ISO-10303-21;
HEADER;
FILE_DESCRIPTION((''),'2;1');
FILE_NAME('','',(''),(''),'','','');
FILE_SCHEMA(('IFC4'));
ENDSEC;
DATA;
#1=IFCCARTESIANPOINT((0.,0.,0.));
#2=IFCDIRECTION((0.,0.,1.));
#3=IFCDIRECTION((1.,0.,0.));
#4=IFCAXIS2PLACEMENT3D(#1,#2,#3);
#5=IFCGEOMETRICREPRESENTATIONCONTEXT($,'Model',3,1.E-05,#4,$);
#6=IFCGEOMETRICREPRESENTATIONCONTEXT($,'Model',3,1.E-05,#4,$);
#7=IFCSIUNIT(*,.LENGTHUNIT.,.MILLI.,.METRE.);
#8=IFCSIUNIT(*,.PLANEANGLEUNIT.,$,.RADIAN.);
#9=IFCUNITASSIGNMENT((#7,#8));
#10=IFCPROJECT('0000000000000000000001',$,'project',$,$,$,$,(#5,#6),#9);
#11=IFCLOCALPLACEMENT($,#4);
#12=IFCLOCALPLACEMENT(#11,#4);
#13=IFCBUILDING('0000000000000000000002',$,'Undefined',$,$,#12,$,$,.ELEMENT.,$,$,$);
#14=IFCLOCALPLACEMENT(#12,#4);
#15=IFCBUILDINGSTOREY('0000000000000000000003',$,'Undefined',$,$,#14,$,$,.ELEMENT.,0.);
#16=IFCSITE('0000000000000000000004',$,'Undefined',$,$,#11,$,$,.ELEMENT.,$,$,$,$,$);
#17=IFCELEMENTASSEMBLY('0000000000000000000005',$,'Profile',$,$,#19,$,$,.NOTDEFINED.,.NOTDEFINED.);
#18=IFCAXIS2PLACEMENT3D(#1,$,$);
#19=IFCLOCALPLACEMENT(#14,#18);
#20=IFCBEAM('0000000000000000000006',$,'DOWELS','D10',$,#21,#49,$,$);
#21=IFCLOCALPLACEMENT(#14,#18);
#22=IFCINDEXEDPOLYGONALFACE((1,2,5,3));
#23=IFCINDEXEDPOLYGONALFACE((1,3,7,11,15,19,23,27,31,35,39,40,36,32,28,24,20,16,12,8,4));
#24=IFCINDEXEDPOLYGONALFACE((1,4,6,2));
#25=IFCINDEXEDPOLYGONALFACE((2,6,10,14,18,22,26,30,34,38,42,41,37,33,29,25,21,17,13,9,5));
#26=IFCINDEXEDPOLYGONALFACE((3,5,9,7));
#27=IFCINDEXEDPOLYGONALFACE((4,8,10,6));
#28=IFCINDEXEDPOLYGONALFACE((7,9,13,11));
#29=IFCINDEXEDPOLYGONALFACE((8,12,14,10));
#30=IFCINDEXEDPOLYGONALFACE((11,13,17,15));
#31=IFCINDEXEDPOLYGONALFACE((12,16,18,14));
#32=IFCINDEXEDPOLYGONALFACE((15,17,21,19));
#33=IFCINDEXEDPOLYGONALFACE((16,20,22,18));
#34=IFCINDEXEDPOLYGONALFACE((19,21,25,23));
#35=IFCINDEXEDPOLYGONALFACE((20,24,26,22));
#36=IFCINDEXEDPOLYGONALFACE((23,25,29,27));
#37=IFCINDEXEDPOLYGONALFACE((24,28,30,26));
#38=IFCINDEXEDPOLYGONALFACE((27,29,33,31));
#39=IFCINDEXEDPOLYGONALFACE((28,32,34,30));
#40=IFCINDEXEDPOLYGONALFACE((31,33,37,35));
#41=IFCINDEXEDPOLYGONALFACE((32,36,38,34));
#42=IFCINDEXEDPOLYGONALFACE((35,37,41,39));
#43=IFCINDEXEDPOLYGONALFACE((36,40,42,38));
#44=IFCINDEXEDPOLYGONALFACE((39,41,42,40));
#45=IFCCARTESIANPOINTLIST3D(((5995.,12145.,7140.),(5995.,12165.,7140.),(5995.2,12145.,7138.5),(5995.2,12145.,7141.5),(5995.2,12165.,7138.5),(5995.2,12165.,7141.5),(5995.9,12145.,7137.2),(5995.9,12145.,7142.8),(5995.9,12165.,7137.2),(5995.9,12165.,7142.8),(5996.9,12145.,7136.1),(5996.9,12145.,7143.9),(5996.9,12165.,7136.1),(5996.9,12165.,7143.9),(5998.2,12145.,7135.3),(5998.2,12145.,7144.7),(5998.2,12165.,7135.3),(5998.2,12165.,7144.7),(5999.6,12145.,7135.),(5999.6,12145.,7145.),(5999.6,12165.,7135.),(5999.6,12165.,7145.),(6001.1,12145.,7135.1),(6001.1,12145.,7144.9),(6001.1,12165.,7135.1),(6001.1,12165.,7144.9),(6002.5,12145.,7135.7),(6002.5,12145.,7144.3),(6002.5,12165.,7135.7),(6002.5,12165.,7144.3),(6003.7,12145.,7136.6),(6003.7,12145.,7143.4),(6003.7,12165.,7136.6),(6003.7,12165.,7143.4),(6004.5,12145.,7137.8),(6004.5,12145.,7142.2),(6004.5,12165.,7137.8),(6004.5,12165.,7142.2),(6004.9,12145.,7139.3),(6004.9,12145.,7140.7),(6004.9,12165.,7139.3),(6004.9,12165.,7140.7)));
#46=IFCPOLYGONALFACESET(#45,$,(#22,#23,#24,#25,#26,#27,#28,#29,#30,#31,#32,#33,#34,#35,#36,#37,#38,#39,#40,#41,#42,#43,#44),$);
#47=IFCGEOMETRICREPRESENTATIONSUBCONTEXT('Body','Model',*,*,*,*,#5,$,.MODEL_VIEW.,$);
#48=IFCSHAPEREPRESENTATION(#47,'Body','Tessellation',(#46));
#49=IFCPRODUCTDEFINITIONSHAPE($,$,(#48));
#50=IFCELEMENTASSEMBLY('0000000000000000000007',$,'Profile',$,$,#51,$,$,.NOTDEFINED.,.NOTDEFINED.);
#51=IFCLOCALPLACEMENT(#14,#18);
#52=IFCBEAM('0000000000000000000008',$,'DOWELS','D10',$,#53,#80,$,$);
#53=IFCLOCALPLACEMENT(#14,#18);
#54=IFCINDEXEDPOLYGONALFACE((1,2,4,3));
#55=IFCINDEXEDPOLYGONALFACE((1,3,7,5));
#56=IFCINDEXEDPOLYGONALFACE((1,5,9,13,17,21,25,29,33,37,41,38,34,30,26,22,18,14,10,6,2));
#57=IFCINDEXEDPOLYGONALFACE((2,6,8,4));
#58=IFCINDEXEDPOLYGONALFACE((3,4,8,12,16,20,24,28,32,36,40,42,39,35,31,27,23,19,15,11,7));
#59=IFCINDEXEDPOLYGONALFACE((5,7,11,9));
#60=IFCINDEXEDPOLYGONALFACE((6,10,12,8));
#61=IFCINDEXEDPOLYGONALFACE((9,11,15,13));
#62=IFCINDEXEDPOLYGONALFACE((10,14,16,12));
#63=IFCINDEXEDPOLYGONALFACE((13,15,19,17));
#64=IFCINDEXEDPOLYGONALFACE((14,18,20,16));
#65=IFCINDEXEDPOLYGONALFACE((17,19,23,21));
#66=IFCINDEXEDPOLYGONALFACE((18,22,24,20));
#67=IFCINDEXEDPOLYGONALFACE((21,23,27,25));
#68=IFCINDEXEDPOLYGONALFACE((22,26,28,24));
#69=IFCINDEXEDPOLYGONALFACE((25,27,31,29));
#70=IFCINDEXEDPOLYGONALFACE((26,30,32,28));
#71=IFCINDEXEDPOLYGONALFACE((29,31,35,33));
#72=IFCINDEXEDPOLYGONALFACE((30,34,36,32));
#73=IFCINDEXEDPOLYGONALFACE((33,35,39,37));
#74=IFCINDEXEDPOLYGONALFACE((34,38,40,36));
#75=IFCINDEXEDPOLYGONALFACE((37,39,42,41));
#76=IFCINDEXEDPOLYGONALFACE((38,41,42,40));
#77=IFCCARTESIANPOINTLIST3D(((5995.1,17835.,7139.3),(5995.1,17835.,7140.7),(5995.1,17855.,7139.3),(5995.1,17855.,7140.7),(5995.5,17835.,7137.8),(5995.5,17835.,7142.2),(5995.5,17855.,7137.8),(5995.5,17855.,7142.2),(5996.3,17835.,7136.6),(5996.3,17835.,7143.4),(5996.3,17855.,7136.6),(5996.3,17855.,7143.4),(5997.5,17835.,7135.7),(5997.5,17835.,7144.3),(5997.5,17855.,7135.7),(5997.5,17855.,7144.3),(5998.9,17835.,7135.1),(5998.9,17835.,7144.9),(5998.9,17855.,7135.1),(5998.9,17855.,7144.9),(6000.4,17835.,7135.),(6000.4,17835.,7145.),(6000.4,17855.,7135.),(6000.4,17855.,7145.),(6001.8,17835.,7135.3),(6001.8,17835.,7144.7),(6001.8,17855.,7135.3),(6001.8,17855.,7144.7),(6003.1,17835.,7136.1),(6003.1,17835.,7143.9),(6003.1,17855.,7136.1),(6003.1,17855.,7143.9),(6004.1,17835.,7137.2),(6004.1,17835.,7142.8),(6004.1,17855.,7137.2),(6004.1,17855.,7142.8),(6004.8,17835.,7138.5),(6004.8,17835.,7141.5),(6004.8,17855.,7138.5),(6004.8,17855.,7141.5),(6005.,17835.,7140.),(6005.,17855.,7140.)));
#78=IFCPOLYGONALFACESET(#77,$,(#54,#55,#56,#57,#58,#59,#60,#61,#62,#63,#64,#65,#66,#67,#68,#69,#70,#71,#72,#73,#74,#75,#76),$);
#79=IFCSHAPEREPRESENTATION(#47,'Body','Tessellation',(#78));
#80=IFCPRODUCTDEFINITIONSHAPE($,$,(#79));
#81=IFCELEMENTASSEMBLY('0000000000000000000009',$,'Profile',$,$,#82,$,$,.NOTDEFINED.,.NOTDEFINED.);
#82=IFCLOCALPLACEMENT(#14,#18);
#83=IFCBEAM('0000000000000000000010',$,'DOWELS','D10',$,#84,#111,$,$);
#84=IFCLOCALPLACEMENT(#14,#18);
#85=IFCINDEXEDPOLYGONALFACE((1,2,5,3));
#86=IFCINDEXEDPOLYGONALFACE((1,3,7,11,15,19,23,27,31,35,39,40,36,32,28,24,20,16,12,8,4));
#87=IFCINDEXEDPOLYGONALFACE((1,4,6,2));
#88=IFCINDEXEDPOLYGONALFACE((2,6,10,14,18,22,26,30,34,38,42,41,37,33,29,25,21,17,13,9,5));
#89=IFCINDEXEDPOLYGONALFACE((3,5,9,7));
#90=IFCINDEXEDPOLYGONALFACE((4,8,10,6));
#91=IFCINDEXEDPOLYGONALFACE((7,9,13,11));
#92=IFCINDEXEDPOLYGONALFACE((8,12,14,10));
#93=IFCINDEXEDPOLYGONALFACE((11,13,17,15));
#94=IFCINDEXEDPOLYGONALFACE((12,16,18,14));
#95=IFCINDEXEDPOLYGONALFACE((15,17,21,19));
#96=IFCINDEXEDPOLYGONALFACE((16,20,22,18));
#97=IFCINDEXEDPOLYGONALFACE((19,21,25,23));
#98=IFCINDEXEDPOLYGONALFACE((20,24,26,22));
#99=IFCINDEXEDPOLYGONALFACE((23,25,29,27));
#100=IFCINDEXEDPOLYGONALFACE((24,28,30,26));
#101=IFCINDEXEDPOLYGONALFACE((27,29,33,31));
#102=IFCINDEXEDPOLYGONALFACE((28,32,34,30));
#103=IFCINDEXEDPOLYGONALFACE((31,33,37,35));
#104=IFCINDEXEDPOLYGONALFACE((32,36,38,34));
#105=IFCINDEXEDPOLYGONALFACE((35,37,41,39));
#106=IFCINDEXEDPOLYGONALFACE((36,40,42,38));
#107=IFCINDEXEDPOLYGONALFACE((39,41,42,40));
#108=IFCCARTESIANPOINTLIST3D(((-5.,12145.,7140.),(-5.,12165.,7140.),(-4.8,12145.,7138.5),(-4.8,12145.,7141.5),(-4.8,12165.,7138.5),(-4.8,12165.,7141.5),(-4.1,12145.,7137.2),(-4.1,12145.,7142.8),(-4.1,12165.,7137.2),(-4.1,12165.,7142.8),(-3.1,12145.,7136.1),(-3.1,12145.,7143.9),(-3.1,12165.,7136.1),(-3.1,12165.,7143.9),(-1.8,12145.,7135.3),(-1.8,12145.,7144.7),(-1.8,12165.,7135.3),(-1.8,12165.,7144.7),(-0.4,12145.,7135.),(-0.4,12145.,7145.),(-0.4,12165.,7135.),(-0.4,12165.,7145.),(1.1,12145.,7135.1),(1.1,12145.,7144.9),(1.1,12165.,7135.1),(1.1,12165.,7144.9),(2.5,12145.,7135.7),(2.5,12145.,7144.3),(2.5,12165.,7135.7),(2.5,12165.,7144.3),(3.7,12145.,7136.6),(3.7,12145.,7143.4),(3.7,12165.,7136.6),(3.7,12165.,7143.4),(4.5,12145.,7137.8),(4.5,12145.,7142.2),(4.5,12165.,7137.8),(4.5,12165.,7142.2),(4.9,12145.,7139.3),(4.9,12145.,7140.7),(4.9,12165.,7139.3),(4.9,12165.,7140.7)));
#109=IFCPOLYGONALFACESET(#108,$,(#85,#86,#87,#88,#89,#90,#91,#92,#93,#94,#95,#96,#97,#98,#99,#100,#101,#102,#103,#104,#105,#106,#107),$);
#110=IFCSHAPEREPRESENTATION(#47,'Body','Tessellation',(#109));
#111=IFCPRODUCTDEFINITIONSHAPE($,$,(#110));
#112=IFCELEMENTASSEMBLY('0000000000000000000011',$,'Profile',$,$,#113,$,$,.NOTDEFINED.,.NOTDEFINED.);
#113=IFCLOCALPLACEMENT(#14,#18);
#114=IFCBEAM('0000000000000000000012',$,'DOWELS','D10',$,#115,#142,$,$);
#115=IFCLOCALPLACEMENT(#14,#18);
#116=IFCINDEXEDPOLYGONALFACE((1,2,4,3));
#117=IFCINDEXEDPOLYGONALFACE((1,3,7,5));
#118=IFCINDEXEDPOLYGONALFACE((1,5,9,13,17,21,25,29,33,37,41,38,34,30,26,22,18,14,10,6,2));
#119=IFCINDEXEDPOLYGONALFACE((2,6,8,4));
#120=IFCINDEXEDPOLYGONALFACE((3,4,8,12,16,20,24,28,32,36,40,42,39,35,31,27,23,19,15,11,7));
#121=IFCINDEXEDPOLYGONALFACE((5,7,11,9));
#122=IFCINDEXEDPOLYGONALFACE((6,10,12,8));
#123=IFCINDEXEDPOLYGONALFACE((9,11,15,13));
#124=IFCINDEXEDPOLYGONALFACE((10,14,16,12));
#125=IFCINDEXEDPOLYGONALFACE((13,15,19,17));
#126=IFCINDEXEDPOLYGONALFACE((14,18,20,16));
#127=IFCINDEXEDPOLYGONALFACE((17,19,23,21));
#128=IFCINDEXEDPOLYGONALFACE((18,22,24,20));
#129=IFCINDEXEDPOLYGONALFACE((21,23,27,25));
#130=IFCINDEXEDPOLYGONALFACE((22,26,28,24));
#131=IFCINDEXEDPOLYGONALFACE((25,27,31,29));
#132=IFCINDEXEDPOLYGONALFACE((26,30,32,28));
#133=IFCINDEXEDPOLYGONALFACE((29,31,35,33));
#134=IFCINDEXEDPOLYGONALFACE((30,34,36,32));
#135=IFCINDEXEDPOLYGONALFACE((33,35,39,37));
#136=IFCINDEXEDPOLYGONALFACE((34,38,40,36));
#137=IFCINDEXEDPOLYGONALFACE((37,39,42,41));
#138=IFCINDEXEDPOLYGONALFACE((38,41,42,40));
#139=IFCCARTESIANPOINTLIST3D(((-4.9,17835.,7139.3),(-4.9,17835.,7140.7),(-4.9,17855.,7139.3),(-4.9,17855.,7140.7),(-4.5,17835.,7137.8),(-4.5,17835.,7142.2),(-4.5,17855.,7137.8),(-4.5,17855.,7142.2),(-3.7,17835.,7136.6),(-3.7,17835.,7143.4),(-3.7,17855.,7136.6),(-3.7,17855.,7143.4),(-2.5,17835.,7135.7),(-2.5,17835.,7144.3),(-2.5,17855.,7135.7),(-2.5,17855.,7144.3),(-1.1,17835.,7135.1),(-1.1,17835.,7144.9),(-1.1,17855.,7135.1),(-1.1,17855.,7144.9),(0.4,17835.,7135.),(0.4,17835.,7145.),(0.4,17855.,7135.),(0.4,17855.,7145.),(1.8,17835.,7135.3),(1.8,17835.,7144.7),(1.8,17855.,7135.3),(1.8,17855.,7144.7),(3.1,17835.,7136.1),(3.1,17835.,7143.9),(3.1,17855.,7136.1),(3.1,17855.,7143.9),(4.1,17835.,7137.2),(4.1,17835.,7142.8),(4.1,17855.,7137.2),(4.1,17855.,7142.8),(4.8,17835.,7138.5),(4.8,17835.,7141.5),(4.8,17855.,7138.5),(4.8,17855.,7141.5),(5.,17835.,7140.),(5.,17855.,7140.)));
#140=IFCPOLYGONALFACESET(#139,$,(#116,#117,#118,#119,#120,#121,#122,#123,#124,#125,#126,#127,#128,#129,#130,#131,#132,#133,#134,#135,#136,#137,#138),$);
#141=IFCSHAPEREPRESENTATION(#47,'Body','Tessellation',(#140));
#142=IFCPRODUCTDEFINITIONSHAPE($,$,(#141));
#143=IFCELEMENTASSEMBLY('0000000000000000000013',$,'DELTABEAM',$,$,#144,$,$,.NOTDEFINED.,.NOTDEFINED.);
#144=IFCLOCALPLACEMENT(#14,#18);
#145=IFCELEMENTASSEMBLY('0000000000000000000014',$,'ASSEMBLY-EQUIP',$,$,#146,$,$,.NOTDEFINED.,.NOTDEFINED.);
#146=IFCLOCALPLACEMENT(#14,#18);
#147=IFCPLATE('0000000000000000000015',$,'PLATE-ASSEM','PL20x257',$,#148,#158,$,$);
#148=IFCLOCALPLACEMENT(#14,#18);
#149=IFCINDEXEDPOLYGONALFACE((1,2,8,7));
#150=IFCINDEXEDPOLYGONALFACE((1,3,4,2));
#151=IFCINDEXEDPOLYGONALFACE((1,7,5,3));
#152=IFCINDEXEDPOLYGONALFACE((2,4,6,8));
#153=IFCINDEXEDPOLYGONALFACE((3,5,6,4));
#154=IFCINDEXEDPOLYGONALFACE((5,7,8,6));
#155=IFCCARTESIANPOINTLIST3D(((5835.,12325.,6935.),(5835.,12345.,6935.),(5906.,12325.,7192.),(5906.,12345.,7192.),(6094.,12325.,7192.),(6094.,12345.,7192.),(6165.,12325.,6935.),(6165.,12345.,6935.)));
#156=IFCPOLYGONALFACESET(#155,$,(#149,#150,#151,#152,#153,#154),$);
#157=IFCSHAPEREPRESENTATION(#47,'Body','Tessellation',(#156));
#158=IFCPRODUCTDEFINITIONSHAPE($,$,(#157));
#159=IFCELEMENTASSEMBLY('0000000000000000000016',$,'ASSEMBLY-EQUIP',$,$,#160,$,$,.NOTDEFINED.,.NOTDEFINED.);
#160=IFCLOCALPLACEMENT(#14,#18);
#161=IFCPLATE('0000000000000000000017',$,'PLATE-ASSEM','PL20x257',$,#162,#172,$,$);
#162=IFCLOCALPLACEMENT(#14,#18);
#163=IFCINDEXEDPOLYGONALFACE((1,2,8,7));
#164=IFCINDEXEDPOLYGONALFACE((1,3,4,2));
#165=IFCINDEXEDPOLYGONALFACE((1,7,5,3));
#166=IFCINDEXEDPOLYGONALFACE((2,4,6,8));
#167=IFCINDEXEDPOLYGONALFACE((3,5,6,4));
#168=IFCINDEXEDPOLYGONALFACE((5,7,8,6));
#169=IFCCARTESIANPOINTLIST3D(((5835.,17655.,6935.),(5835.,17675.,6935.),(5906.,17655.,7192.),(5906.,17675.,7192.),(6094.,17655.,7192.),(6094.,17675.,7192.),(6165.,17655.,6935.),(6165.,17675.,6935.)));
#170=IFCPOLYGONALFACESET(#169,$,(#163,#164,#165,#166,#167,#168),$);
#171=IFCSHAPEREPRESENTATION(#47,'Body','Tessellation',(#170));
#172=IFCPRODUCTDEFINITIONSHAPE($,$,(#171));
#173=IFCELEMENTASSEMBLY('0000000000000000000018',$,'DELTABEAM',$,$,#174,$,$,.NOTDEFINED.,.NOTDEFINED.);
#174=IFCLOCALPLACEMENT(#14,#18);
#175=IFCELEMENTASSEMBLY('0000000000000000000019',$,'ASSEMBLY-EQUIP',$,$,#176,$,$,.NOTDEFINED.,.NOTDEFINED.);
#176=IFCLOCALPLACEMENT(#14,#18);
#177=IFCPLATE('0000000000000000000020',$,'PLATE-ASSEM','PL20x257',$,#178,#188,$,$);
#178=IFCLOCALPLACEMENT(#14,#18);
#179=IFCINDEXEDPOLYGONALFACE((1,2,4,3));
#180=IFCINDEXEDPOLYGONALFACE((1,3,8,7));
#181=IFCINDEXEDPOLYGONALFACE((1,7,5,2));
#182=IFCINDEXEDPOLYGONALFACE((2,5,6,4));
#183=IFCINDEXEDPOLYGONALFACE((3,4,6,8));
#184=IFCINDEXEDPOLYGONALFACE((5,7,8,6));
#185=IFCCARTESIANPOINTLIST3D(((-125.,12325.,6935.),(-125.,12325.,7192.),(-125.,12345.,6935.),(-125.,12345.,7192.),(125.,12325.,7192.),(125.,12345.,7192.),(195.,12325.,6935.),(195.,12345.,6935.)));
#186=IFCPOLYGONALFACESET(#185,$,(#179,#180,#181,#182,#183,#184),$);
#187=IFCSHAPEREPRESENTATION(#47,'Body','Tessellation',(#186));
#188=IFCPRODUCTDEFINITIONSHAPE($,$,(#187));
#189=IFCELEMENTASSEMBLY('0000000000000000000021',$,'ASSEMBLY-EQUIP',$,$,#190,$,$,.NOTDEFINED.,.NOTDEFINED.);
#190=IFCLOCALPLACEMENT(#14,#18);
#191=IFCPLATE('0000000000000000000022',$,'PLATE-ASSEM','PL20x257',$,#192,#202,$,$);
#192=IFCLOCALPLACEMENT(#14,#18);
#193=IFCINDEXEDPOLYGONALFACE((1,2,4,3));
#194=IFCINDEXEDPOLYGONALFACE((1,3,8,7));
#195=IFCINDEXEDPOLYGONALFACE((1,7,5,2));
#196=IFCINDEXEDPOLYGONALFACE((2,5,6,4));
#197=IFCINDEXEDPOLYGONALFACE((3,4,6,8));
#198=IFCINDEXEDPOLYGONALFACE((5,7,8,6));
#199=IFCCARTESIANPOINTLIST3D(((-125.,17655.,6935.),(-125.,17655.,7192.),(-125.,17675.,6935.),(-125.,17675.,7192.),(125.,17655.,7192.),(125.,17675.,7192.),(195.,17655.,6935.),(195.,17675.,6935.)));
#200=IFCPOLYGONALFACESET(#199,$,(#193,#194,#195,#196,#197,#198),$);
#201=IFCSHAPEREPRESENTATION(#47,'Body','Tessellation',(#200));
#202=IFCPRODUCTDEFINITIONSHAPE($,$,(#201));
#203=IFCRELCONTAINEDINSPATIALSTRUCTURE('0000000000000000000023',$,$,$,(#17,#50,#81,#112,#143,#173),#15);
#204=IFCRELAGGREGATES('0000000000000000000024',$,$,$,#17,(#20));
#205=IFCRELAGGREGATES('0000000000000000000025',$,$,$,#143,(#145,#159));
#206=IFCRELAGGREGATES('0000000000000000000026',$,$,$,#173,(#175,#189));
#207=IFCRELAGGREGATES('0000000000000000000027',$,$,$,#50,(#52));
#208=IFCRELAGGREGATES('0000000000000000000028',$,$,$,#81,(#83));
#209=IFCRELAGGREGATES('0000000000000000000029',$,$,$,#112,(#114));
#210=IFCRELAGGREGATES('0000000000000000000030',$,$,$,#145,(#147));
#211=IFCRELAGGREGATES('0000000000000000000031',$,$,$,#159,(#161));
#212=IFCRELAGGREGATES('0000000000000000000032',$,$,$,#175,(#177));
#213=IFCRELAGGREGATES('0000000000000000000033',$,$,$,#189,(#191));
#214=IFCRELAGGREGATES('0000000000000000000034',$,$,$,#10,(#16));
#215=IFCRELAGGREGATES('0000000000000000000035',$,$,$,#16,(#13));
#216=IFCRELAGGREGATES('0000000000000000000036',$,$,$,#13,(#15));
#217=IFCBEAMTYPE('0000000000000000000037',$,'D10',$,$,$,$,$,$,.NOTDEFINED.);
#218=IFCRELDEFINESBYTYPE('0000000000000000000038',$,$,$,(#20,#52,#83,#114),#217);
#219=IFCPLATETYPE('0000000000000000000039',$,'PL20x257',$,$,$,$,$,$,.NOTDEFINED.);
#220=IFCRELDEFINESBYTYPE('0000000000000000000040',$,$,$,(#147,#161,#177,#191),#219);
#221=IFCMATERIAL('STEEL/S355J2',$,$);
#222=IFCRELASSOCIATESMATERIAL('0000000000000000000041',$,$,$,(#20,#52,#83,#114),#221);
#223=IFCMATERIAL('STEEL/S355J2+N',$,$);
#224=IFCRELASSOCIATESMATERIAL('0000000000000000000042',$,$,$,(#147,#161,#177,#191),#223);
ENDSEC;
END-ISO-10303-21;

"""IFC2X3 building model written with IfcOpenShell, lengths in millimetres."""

from ifc_helpers import new_model, si_unit, frame, origin_with_axes, origin_2d_with_axis, place, context, subcontext, project, spatial, polyline, circle, outline, extrude, material, type_object, element, aggregate, save


model = new_model("IFC2X3")

# Units and contexts
model_context_1 = context("Model", 3, precision=1e-05, world=origin_with_axes())
model_context_2 = context("Model", 3, precision=1e-05, world=origin_with_axes())
body_context = subcontext(model_context_1, "Body", "Model", "MODEL_VIEW")
ifc_project = project(units=[si_unit("LENGTHUNIT", "METRE", prefix="MILLI"), si_unit("PLANEANGLEUNIT", "RADIAN")], contexts=[model_context_1, model_context_2])

# Site, building, storey
site_placement = place(None, origin_with_axes())
site = spatial("IfcSite", under=ifc_project, at=site_placement, Name="Undefined", CompositionType="ELEMENT")
building_placement = place(site_placement, origin_with_axes())
building = spatial("IfcBuilding", under=site, at=building_placement, Name="Undefined", CompositionType="ELEMENT")
storey_placement = place(building_placement, origin_with_axes())
storey = spatial("IfcBuildingStorey", under=building, at=storey_placement, Name="Undefined", CompositionType="ELEMENT", Elevation=0.0)

# Element assemblies, beams
assembly_1_placement = place(storey_placement, origin_with_axes())
assembly_1 = element("IfcElementAssembly", 1, at=assembly_1_placement, inside=storey, Name="Profile", AssemblyPlace="NOTDEFINED", PredefinedType="NOTDEFINED")
ifc_material_1 = material(Name="STEEL/S355J2")
beam_type = type_object("IfcBeamType", Name="D10", PredefinedType="NOTDEFINED")
beam_1_placement = place(assembly_1_placement, frame((6000.0, 12165.0, 7140.0), z_axis=(0.0, 0.0, 1.0), x_axis=(0.0, -1.0, 0.0)))
beam_1 = element("IfcBeam", 2, at=beam_1_placement, type_object=beam_type, material=ifc_material_1, Name="DOWELS", Description="D10", context=body_context, shape_type="SweptSolid", body=[
    extrude(circle(Radius=5.0, at=origin_2d_with_axis()), frame((20.0, 0.0, 0.0), z_axis=(-1.0, 0.0, 0.0), x_axis=(0.0, -1.0, 0.0)), (0.0, 0.0, 1.0), 20.0),
])
aggregate(assembly_1, [beam_1])
assembly_2_placement = place(storey_placement, origin_with_axes())
assembly_2 = element("IfcElementAssembly", 3, at=assembly_2_placement, inside=storey, Name="Profile", AssemblyPlace="NOTDEFINED", PredefinedType="NOTDEFINED")
beam_2_placement = place(assembly_2_placement, frame((6000.0, 17835.0, 7140.0), z_axis=(0.0, 0.0, 1.0), x_axis=(0.0, 1.0, 0.0)))
beam_2 = element("IfcBeam", 4, at=beam_2_placement, type_object=beam_type, material=ifc_material_1, Name="DOWELS", Description="D10", context=body_context, shape_type="SweptSolid", body=[
    extrude(circle(Radius=5.0, at=origin_2d_with_axis()), frame((20.0, 0.0, 0.0), z_axis=(-1.0, 0.0, 0.0), x_axis=(0.0, -1.0, 0.0)), (0.0, 0.0, 1.0), 20.0),
])
assembly_3_placement = place(storey_placement, origin_with_axes())
assembly_3 = element("IfcElementAssembly", 5, at=assembly_3_placement, inside=storey, Name="Profile", AssemblyPlace="NOTDEFINED", PredefinedType="NOTDEFINED")
beam_3_placement = place(assembly_3_placement, frame((0.0, 12165.0, 7140.0), z_axis=(0.0, 0.0, 1.0), x_axis=(0.0, -1.0, 0.0)))
beam_3 = element("IfcBeam", 6, at=beam_3_placement, type_object=beam_type, material=ifc_material_1, Name="DOWELS", Description="D10", context=body_context, shape_type="SweptSolid", body=[
    extrude(circle(Radius=5.0, at=origin_2d_with_axis()), frame((20.0, 0.0, 0.0), z_axis=(-1.0, 0.0, 0.0), x_axis=(0.0, -1.0, 0.0)), (0.0, 0.0, 1.0), 20.0),
])
assembly_4_placement = place(storey_placement, origin_with_axes())
assembly_4 = element("IfcElementAssembly", 7, at=assembly_4_placement, inside=storey, Name="Profile", AssemblyPlace="NOTDEFINED", PredefinedType="NOTDEFINED")
beam_4_placement = place(assembly_4_placement, frame((0.0, 17835.0, 7140.0), z_axis=(0.0, 0.0, 1.0), x_axis=(0.0, 1.0, 0.0)))
beam_4 = element("IfcBeam", 8, at=beam_4_placement, type_object=beam_type, material=ifc_material_1, Name="DOWELS", Description="D10", context=body_context, shape_type="SweptSolid", body=[
    extrude(circle(Radius=5.0, at=origin_2d_with_axis()), frame((20.0, 0.0, 0.0), z_axis=(-1.0, 0.0, 0.0), x_axis=(0.0, -1.0, 0.0)), (0.0, 0.0, 1.0), 20.0),
])

# Element assemblies, plates
assembly_5_placement = place(storey_placement, origin_with_axes())
assembly_5 = element("IfcElementAssembly", 9, at=assembly_5_placement, inside=storey, Name="DELTABEAM", AssemblyPlace="NOTDEFINED", PredefinedType="NOTDEFINED")
assembly_6_placement = place(assembly_5_placement, origin_with_axes())
assembly_6 = element("IfcElementAssembly", 10, at=assembly_6_placement, Name="ASSEMBLY-EQUIP", AssemblyPlace="NOTDEFINED", PredefinedType="NOTDEFINED")
ifc_material_2 = material(Name="STEEL/S355J2+N")
plate_type_1 = type_object("IfcPlateType", Name="PL20x257", PredefinedType="NOTDEFINED")
plate_1_placement = place(assembly_6_placement, frame((6165.0, 12335.0, 6935.0), z_axis=(0.0, 1.0, 0.0), x_axis=(-1.0, 0.0, 0.0)))
plate_1 = element("IfcPlate", 11, at=plate_1_placement, type_object=plate_type_1, material=ifc_material_2, Name="PLATE-ASSEM", Description="PL20x257", context=body_context, shape_type="SweptSolid", body=[
    extrude(outline(polyline([(0.0, 0.0), (330.0, 0.0), (259.0, 257.0), (71.0, 257.0), (0.0, 0.0)])), frame((0.0, 0.0, -10.0), z_axis=(0.0, 0.0, 1.0), x_axis=(1.0, 0.0, 0.0)), (0.0, 0.0, 1.0), 20.0),
])
assembly_7_placement = place(assembly_5_placement, origin_with_axes())
assembly_7 = element("IfcElementAssembly", 12, at=assembly_7_placement, Name="ASSEMBLY-EQUIP", AssemblyPlace="NOTDEFINED", PredefinedType="NOTDEFINED")
aggregate(assembly_5, [assembly_6, assembly_7])
plate_2_placement = place(assembly_7_placement, frame((5835.0, 17665.0, 6935.0), z_axis=(0.0, -1.0, 0.0), x_axis=(1.0, 0.0, 0.0)))
plate_2 = element("IfcPlate", 13, at=plate_2_placement, type_object=plate_type_1, material=ifc_material_2, Name="PLATE-ASSEM", Description="PL20x257", context=body_context, shape_type="SweptSolid", body=[
    extrude(outline(polyline([(0.0, 0.0), (330.0, 0.0), (259.0, 257.0), (71.0, 257.0), (0.0, 0.0)])), frame((0.0, 0.0, -10.0), z_axis=(0.0, 0.0, 1.0), x_axis=(1.0, 0.0, 0.0)), (0.0, 0.0, 1.0), 20.0),
])
assembly_8_placement = place(storey_placement, origin_with_axes())
assembly_8 = element("IfcElementAssembly", 14, at=assembly_8_placement, inside=storey, Name="DELTABEAM", AssemblyPlace="NOTDEFINED", PredefinedType="NOTDEFINED")
assembly_9_placement = place(assembly_8_placement, origin_with_axes())
assembly_9 = element("IfcElementAssembly", 15, at=assembly_9_placement, Name="ASSEMBLY-EQUIP", AssemblyPlace="NOTDEFINED", PredefinedType="NOTDEFINED")
plate_3_placement = place(assembly_9_placement, frame((195.0, 12335.0, 6935.0), z_axis=(0.0, 1.0, 0.0), x_axis=(-1.0, 0.0, 0.0)))
plate_3 = element("IfcPlate", 16, at=plate_3_placement, type_object=plate_type_1, material=ifc_material_2, Name="PLATE-ASSEM", Description="PL20x257", context=body_context, shape_type="SweptSolid", body=[
    extrude(outline(polyline([(0.0, 0.0), (320.0, 0.0), (320.0, 257.0), (70.0, 257.0), (0.0, 0.0)])), frame((0.0, 0.0, -10.0), z_axis=(0.0, 0.0, 1.0), x_axis=(1.0, 0.0, 0.0)), (0.0, 0.0, 1.0), 20.0),
])
assembly_10_placement = place(assembly_8_placement, origin_with_axes())
assembly_10 = element("IfcElementAssembly", 17, at=assembly_10_placement, Name="ASSEMBLY-EQUIP", AssemblyPlace="NOTDEFINED", PredefinedType="NOTDEFINED")
aggregate(assembly_8, [assembly_9, assembly_10])
plate_4_placement = place(assembly_10_placement, frame((-125.0, 17665.0, 6935.0), z_axis=(0.0, -1.0, 0.0), x_axis=(1.0, 0.0, 0.0)))
plate_4 = element("IfcPlate", 18, at=plate_4_placement, type_object=plate_type_1, material=ifc_material_2, Name="PLATE-ASSEM", Description="PL20x257", context=body_context, shape_type="SweptSolid", body=[
    extrude(outline(polyline([(0.0, 0.0), (320.0, 0.0), (250.0, 257.0), (0.0, 257.0), (0.0, 0.0)])), frame((0.0, 0.0, -10.0), z_axis=(0.0, 0.0, 1.0), x_axis=(1.0, 0.0, 0.0)), (0.0, 0.0, 1.0), 20.0),
])

aggregate(assembly_2, [beam_2])
aggregate(assembly_3, [beam_3])
aggregate(assembly_4, [beam_4])

aggregate(assembly_6, [plate_1])
aggregate(assembly_7, [plate_2])
aggregate(assembly_9, [plate_3])
aggregate(assembly_10, [plate_4])

save(model, "model.ifc")
